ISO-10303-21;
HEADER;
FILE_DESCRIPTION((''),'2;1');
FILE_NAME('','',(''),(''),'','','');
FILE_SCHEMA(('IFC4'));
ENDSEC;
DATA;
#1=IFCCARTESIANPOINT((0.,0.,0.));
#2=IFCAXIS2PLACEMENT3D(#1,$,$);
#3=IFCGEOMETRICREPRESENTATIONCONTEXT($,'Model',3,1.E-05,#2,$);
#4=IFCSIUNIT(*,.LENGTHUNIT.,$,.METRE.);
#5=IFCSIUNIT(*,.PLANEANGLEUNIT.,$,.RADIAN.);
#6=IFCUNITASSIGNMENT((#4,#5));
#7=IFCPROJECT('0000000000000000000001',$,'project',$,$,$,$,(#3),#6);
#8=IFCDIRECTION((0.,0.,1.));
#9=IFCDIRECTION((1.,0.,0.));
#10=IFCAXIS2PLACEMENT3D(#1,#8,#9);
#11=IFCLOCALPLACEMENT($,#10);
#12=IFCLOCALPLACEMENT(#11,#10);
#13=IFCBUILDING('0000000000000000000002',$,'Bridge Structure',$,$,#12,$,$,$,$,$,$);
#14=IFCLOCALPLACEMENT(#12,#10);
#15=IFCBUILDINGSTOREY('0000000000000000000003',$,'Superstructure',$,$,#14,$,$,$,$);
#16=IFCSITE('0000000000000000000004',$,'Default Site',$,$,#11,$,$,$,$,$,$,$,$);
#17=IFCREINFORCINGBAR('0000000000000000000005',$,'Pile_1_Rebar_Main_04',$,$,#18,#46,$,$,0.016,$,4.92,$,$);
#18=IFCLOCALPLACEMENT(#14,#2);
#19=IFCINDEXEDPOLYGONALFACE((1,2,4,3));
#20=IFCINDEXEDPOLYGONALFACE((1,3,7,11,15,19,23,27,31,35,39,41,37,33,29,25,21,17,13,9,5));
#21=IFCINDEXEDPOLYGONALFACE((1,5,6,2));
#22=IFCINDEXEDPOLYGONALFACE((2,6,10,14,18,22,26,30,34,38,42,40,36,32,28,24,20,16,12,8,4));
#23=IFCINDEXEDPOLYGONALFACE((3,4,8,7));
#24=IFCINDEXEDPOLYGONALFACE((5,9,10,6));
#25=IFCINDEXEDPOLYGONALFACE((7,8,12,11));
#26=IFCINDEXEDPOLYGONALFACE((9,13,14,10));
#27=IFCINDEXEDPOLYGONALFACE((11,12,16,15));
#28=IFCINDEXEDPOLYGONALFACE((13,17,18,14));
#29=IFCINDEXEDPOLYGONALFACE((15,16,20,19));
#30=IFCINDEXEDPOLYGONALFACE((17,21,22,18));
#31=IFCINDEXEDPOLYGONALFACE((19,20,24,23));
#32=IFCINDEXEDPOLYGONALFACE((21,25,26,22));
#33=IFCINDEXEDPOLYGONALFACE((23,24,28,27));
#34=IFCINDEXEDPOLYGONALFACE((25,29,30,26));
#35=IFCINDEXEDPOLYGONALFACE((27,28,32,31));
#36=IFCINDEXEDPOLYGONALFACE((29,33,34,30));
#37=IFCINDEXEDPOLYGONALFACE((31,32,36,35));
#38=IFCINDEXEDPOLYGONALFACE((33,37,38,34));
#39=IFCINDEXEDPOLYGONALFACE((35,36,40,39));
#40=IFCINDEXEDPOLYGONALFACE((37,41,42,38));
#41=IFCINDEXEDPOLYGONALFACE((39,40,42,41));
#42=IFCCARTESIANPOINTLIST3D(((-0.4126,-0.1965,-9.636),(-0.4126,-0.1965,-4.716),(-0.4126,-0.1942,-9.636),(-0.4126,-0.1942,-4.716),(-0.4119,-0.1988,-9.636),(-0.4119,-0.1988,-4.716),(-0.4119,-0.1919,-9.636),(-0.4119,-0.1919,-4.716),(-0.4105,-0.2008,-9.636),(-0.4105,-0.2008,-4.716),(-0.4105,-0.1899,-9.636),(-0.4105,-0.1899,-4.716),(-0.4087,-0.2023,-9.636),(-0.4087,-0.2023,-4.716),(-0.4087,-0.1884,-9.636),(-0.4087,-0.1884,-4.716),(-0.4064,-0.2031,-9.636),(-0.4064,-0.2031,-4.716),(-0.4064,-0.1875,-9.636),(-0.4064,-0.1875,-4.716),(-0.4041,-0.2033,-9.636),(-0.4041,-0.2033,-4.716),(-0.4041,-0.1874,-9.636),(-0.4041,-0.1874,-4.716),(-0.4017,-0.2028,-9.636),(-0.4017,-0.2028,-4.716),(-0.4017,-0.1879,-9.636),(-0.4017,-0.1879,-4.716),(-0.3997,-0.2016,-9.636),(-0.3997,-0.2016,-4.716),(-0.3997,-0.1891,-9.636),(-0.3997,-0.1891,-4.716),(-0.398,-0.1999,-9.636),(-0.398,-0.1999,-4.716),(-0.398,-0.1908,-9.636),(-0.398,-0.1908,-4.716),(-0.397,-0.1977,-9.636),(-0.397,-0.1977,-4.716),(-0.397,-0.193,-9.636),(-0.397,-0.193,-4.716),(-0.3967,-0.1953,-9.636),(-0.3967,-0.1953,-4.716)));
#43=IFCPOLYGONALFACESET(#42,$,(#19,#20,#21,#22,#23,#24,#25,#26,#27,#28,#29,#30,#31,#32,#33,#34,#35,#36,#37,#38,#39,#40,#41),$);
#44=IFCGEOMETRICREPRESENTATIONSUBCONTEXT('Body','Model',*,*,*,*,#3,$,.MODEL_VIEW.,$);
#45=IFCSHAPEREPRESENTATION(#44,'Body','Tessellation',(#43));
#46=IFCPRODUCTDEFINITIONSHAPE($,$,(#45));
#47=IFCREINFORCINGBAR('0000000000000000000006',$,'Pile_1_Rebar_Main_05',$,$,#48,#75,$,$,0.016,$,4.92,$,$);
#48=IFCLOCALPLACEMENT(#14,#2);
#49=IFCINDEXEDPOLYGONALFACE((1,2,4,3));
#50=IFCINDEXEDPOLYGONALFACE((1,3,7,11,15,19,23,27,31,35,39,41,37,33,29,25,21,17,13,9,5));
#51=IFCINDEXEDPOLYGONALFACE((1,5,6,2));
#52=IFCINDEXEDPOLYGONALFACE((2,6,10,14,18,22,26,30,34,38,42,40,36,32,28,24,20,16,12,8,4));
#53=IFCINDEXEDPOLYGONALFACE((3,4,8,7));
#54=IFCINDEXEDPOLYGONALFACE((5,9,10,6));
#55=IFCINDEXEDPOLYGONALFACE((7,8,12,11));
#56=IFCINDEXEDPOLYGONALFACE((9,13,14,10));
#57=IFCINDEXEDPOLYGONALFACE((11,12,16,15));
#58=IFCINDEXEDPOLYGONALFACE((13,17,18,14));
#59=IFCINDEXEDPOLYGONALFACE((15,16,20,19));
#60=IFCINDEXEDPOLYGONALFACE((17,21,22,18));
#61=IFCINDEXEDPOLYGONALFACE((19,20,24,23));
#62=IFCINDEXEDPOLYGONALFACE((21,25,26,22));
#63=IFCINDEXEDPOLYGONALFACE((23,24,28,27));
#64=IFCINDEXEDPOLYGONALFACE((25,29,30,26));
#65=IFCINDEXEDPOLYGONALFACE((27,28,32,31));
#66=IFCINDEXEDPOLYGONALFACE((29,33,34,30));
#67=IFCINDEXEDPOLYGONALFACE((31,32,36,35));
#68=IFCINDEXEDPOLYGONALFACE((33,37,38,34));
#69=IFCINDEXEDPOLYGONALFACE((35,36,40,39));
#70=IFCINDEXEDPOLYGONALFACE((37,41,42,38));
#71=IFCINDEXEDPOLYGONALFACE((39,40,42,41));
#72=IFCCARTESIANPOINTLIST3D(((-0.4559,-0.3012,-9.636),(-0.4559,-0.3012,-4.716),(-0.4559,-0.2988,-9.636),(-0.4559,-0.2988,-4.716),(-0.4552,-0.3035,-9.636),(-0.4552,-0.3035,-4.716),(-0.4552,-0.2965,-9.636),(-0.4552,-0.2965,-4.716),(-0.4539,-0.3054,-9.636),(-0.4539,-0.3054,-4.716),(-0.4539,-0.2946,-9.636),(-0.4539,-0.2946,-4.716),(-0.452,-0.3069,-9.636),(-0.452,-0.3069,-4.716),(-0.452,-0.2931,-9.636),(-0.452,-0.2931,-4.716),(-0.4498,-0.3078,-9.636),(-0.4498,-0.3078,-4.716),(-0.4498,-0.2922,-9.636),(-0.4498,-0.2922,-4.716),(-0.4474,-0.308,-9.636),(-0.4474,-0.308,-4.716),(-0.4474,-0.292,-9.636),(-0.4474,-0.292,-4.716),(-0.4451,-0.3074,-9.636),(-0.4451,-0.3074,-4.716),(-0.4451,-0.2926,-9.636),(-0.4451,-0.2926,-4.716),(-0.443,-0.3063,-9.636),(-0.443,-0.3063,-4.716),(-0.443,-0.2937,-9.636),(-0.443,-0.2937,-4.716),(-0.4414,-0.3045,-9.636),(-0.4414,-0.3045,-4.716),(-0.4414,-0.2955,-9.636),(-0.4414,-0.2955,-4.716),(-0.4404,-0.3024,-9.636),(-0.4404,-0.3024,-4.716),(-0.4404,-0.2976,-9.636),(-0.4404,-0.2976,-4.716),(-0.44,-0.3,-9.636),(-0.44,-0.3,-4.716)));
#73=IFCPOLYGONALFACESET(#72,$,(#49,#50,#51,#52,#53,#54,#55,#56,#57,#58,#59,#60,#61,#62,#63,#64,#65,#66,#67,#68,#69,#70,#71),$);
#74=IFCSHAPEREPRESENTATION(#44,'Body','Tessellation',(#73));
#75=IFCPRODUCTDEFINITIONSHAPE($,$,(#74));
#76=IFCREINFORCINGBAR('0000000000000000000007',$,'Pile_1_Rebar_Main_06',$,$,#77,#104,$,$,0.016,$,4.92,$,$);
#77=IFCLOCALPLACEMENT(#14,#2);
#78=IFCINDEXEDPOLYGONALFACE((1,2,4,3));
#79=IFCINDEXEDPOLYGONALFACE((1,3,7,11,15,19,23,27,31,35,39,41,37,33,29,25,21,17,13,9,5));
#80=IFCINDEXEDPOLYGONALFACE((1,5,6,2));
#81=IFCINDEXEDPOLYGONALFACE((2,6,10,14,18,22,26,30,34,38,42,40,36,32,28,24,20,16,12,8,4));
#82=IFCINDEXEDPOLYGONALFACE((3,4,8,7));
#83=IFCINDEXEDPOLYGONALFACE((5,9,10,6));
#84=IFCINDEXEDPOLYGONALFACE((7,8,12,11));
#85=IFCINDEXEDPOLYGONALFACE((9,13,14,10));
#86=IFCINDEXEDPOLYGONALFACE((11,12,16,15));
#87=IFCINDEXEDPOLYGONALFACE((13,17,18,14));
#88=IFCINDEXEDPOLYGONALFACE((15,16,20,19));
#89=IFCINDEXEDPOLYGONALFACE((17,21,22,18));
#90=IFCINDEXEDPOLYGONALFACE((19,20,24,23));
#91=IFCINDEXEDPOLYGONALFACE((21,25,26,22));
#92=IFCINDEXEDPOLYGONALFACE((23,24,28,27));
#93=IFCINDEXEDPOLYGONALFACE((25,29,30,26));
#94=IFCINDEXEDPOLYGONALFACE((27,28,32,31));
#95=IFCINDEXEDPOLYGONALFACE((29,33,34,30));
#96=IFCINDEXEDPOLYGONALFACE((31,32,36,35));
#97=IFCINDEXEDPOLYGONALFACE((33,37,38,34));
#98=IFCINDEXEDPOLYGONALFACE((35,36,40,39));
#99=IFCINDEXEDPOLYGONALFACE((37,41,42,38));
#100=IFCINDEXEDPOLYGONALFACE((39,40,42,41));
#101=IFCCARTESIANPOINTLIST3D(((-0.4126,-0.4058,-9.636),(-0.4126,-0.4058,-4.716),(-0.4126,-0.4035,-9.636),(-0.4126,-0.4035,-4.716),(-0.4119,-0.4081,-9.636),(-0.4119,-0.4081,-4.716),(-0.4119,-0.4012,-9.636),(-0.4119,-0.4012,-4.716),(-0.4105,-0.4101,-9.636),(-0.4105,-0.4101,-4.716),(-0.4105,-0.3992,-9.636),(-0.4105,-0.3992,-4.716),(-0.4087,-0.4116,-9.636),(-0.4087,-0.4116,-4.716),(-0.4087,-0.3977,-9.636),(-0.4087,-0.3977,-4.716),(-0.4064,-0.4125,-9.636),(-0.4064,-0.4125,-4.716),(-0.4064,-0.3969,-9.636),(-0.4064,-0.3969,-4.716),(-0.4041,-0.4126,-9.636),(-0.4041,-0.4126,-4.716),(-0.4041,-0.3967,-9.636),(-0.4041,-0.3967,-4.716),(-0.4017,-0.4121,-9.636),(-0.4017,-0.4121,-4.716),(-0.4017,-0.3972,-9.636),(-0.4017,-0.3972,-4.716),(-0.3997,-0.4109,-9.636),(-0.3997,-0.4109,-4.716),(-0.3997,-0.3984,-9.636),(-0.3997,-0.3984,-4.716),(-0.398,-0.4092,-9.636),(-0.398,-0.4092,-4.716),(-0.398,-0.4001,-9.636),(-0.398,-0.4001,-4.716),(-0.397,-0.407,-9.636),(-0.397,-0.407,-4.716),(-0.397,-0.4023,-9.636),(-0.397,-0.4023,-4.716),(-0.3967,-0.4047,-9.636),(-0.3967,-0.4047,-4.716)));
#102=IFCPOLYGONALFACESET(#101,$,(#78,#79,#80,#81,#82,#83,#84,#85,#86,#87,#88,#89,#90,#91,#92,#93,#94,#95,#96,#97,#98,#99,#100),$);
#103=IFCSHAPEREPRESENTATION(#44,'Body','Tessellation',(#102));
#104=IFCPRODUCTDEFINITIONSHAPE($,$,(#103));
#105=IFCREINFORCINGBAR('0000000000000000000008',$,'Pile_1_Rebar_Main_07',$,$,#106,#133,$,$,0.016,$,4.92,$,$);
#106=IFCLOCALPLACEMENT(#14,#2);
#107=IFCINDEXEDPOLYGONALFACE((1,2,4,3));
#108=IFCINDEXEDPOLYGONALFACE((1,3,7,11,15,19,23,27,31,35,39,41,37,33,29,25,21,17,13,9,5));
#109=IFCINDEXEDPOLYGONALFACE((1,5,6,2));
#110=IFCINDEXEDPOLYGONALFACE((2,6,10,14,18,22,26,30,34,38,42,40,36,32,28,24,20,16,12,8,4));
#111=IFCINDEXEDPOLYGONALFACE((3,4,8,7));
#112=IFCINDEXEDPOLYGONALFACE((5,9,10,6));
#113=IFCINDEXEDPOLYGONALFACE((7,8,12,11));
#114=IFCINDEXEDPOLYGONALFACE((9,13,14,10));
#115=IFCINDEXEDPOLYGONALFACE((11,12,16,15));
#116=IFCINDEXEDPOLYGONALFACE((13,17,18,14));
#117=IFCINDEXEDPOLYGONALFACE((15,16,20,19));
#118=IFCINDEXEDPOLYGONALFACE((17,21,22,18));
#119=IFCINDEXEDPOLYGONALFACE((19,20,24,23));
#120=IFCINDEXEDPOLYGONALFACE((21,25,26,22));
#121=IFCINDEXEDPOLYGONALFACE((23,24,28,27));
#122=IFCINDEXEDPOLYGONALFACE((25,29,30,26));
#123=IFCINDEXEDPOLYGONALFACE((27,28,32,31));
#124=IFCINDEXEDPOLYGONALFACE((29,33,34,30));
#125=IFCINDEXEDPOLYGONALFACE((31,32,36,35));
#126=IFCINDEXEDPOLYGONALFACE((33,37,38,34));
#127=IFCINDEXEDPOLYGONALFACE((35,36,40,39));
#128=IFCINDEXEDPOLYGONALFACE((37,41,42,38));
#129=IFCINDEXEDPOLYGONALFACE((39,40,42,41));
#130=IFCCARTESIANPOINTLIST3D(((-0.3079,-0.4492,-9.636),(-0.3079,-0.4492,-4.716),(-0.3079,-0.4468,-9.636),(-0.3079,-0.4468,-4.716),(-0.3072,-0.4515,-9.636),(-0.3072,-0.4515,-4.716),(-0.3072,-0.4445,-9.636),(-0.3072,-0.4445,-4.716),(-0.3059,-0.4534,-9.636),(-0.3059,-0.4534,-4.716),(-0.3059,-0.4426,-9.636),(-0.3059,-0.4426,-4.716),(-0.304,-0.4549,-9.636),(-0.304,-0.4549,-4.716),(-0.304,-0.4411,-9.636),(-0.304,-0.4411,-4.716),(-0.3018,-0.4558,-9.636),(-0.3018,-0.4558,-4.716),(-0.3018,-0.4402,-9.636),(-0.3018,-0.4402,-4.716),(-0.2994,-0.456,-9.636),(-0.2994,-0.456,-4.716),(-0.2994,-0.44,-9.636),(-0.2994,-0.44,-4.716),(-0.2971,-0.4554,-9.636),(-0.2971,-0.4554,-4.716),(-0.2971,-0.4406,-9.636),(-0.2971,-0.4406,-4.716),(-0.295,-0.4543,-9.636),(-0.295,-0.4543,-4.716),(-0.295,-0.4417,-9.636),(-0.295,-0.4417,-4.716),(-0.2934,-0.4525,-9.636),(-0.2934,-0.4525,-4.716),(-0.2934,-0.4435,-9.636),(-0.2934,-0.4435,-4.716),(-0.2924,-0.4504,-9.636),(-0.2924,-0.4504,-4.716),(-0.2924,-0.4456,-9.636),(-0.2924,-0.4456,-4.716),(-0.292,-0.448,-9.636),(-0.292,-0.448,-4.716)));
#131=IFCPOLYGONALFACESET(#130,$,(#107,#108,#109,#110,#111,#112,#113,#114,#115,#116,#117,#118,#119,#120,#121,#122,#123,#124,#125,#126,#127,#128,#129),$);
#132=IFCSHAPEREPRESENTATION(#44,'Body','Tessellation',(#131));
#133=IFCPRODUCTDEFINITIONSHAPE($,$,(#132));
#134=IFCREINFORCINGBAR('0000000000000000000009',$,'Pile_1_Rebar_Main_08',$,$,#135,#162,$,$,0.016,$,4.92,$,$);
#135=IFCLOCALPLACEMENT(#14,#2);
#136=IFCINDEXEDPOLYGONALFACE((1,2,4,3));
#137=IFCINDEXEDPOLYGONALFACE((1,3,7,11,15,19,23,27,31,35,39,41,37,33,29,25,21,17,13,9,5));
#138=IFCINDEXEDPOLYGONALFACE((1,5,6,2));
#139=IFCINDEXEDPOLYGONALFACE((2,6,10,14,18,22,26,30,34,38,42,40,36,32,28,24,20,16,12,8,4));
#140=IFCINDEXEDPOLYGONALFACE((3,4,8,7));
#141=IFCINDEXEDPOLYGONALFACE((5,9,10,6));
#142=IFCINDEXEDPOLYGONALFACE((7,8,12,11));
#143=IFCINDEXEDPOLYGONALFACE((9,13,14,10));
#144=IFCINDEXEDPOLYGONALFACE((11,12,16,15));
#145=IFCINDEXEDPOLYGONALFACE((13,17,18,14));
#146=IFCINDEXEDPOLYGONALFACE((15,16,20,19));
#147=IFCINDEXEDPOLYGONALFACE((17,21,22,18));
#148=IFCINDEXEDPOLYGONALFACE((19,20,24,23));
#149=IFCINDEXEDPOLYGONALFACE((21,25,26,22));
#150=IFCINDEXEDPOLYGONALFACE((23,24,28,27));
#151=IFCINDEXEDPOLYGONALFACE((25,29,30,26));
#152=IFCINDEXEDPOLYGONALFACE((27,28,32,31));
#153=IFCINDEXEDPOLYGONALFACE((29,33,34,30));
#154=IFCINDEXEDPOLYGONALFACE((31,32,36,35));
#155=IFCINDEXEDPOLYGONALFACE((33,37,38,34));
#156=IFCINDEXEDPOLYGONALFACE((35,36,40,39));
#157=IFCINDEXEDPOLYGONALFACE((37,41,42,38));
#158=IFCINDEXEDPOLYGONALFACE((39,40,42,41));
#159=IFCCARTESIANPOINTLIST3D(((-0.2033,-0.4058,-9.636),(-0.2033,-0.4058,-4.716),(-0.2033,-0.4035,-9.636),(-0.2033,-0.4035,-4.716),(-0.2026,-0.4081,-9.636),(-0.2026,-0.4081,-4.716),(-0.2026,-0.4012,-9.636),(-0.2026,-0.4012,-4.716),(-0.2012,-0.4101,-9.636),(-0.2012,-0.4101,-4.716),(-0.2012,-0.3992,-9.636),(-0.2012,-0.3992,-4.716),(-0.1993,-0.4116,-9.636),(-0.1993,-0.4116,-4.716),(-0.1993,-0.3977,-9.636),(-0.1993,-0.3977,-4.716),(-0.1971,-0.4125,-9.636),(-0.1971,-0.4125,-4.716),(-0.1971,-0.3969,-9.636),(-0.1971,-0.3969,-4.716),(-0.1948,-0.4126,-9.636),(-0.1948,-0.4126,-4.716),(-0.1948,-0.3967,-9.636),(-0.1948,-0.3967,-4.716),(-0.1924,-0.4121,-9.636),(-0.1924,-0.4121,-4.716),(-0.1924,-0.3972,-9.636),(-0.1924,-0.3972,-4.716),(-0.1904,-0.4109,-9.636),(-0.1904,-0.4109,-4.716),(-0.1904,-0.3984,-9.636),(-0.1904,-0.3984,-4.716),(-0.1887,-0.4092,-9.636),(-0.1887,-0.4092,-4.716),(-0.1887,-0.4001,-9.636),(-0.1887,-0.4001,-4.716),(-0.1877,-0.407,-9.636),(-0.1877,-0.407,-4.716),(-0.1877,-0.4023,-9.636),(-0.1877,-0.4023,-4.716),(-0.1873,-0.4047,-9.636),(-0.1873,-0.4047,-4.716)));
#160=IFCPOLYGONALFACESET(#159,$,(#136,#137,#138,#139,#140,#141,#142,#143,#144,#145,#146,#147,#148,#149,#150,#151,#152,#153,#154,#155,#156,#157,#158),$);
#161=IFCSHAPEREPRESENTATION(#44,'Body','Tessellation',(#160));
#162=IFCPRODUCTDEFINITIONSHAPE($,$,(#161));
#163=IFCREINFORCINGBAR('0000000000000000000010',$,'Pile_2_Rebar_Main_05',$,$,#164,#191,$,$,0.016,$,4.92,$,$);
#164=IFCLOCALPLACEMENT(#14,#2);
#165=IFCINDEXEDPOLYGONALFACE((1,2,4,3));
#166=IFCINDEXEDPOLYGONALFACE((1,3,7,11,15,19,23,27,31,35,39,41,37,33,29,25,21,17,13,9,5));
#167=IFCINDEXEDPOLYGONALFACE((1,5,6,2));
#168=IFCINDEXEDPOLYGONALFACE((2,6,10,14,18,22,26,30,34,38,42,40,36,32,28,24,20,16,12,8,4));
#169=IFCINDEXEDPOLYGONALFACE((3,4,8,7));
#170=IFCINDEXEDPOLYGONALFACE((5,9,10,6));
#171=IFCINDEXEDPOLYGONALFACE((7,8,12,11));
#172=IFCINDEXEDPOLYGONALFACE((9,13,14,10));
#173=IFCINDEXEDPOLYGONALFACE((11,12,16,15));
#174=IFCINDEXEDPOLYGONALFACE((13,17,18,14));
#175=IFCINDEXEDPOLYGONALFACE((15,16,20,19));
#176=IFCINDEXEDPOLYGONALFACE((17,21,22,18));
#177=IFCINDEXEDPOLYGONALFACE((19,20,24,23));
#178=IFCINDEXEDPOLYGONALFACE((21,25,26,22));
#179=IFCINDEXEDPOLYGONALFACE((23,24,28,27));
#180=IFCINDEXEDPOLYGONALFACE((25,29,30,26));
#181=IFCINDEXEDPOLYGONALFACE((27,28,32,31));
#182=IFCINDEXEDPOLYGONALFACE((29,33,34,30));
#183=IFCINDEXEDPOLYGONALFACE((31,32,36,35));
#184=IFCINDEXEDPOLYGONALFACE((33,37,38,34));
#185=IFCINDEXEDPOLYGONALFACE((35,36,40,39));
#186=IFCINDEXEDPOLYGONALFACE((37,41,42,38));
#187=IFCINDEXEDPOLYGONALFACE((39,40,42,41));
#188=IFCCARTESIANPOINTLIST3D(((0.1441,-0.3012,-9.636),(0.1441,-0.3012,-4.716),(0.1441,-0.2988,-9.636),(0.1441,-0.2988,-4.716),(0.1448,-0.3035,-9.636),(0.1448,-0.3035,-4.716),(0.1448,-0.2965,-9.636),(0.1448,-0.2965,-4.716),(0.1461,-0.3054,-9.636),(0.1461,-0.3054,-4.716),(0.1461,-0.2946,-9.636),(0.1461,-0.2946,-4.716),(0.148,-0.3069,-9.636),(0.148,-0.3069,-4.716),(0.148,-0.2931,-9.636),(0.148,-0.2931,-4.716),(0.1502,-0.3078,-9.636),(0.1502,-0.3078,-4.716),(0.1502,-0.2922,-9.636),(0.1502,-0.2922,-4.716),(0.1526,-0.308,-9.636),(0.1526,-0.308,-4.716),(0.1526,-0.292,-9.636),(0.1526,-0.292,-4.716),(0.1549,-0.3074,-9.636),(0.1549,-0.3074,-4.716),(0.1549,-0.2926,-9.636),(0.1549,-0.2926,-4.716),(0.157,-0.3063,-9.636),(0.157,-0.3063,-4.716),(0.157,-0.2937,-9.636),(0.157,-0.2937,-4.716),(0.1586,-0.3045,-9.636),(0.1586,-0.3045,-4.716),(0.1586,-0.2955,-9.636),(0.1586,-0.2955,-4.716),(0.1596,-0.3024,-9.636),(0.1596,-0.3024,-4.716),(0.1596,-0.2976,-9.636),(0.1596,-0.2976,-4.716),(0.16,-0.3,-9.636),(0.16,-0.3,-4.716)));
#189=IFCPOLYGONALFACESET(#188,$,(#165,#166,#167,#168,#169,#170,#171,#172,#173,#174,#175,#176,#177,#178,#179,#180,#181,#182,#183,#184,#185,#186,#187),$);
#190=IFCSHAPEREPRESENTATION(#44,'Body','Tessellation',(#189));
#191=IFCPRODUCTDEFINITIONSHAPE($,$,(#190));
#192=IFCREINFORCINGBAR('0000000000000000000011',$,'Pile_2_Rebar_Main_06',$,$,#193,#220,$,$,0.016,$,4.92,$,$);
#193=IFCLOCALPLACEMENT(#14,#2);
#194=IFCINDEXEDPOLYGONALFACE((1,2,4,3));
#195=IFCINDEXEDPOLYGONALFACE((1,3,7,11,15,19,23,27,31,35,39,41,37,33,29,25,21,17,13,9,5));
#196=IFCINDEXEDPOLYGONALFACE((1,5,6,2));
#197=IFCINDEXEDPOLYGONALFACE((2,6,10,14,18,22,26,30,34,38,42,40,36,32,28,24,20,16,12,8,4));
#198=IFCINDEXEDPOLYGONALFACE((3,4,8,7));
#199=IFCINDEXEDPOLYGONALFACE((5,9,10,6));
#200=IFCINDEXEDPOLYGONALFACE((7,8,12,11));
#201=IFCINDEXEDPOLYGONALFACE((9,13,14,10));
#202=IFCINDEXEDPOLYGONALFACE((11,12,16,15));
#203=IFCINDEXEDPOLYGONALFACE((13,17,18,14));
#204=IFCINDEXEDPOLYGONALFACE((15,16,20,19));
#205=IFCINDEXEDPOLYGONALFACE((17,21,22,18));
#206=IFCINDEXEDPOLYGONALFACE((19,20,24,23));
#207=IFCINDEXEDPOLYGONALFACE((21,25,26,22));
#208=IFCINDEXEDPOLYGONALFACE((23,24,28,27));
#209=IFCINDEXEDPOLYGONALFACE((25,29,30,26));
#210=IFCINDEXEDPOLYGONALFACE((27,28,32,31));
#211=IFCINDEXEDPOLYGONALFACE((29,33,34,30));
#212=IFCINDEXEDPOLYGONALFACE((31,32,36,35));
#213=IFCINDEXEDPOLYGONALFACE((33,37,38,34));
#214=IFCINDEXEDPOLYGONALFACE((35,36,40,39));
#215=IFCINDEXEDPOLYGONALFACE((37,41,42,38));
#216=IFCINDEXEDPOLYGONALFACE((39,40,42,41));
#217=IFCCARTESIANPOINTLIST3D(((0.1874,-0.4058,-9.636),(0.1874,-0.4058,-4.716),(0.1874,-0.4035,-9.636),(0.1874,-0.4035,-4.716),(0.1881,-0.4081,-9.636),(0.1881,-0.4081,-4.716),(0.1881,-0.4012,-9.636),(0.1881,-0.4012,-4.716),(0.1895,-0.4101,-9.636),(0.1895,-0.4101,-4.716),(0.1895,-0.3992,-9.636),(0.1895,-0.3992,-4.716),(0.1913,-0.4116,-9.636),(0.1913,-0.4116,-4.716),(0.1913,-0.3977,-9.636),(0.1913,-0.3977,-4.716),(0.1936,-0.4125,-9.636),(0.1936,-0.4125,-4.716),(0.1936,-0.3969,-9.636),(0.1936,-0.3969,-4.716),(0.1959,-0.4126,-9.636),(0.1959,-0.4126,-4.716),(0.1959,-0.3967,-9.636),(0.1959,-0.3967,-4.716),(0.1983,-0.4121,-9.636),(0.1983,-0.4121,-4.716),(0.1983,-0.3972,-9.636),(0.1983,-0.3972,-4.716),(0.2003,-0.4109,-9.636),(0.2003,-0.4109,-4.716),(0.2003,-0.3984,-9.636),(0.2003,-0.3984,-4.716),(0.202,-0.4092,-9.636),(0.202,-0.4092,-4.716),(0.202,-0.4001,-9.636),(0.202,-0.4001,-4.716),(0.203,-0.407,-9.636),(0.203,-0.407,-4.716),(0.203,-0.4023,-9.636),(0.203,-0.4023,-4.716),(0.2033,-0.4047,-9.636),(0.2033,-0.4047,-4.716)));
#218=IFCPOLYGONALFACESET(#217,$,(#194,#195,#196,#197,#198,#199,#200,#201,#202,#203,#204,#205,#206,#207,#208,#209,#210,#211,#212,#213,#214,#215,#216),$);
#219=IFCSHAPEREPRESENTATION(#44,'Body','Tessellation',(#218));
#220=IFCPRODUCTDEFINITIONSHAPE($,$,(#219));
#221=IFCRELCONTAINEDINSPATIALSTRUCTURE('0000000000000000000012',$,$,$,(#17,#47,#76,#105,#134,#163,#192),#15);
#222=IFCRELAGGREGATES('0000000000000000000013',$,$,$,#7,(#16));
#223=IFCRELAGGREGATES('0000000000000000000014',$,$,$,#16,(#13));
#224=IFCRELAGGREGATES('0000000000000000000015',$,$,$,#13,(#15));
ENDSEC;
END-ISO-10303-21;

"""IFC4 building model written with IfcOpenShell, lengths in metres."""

from ifc_helpers import new_model, si_unit, frame, origin, origin_with_axes, origin_2d_with_axis, place, context, subcontext, project, spatial, circle, extrude, element, save


model = new_model("IFC4")

# Units and contexts
model_context = context("Model", 3, precision=1e-05, world=origin())
body_context = subcontext(model_context, "Body", "Model", "MODEL_VIEW")
ifc_project = project(units=[si_unit("LENGTHUNIT", "METRE"), si_unit("PLANEANGLEUNIT", "RADIAN")], contexts=[model_context])

# Site, building, storey
site_placement = place(None, origin_with_axes())
site = spatial("IfcSite", under=ifc_project, at=site_placement, Name="Default Site")
building_placement = place(site_placement, origin_with_axes())
building = spatial("IfcBuilding", under=site, at=building_placement, Name="Bridge Structure")
storey_placement = place(building_placement, origin_with_axes())
storey = spatial("IfcBuildingStorey", under=building, at=storey_placement, Name="Superstructure")

# Reinforcing bars
for number, where, z_axis, x_axis, name in (
    (1, (-0.4047, -0.1953, -9.636), (0.0, 0.0, 1.0), (1.0, 0.0, 0.0), "Pile_1_Rebar_Main_04"),
    (2, (-0.448, -0.3, -9.636), (0.0, 0.0, 1.0), (1.0, 0.0, 0.0), "Pile_1_Rebar_Main_05"),
    (3, (-0.4047, -0.4047, -9.636), (0.0, 0.0, 1.0), (1.0, 0.0, 0.0), "Pile_1_Rebar_Main_06"),
    (4, (-0.3, -0.448, -9.636), (0.0, 0.0, 1.0), (1.0, 0.0, 0.0), "Pile_1_Rebar_Main_07"),
    (5, (-0.1953, -0.4047, -9.636), (0.0, 0.0, 1.0), (1.0, 0.0, 0.0), "Pile_1_Rebar_Main_08"),
    (6, (0.152, -0.3, -9.636), (0.0, 0.0, 1.0), (1.0, 0.0, 0.0), "Pile_2_Rebar_Main_05"),
    (7, (0.1953, -0.4047, -9.636), (0.0, 0.0, 1.0), (1.0, 0.0, 0.0), "Pile_2_Rebar_Main_06"),
):
    element("IfcReinforcingBar", number, at=place(storey_placement, frame(where, z_axis=z_axis, x_axis=x_axis)), inside=storey, Name=name, BarLength=4.92, NominalDiameter=0.016, context=body_context, shape_type="SweptSolid", body=[
        extrude(circle(Radius=0.008, at=origin_2d_with_axis()), origin_with_axes(), (0.0, 0.0, 1.0), 4.92),
    ])

save(model, "model.ifc")
